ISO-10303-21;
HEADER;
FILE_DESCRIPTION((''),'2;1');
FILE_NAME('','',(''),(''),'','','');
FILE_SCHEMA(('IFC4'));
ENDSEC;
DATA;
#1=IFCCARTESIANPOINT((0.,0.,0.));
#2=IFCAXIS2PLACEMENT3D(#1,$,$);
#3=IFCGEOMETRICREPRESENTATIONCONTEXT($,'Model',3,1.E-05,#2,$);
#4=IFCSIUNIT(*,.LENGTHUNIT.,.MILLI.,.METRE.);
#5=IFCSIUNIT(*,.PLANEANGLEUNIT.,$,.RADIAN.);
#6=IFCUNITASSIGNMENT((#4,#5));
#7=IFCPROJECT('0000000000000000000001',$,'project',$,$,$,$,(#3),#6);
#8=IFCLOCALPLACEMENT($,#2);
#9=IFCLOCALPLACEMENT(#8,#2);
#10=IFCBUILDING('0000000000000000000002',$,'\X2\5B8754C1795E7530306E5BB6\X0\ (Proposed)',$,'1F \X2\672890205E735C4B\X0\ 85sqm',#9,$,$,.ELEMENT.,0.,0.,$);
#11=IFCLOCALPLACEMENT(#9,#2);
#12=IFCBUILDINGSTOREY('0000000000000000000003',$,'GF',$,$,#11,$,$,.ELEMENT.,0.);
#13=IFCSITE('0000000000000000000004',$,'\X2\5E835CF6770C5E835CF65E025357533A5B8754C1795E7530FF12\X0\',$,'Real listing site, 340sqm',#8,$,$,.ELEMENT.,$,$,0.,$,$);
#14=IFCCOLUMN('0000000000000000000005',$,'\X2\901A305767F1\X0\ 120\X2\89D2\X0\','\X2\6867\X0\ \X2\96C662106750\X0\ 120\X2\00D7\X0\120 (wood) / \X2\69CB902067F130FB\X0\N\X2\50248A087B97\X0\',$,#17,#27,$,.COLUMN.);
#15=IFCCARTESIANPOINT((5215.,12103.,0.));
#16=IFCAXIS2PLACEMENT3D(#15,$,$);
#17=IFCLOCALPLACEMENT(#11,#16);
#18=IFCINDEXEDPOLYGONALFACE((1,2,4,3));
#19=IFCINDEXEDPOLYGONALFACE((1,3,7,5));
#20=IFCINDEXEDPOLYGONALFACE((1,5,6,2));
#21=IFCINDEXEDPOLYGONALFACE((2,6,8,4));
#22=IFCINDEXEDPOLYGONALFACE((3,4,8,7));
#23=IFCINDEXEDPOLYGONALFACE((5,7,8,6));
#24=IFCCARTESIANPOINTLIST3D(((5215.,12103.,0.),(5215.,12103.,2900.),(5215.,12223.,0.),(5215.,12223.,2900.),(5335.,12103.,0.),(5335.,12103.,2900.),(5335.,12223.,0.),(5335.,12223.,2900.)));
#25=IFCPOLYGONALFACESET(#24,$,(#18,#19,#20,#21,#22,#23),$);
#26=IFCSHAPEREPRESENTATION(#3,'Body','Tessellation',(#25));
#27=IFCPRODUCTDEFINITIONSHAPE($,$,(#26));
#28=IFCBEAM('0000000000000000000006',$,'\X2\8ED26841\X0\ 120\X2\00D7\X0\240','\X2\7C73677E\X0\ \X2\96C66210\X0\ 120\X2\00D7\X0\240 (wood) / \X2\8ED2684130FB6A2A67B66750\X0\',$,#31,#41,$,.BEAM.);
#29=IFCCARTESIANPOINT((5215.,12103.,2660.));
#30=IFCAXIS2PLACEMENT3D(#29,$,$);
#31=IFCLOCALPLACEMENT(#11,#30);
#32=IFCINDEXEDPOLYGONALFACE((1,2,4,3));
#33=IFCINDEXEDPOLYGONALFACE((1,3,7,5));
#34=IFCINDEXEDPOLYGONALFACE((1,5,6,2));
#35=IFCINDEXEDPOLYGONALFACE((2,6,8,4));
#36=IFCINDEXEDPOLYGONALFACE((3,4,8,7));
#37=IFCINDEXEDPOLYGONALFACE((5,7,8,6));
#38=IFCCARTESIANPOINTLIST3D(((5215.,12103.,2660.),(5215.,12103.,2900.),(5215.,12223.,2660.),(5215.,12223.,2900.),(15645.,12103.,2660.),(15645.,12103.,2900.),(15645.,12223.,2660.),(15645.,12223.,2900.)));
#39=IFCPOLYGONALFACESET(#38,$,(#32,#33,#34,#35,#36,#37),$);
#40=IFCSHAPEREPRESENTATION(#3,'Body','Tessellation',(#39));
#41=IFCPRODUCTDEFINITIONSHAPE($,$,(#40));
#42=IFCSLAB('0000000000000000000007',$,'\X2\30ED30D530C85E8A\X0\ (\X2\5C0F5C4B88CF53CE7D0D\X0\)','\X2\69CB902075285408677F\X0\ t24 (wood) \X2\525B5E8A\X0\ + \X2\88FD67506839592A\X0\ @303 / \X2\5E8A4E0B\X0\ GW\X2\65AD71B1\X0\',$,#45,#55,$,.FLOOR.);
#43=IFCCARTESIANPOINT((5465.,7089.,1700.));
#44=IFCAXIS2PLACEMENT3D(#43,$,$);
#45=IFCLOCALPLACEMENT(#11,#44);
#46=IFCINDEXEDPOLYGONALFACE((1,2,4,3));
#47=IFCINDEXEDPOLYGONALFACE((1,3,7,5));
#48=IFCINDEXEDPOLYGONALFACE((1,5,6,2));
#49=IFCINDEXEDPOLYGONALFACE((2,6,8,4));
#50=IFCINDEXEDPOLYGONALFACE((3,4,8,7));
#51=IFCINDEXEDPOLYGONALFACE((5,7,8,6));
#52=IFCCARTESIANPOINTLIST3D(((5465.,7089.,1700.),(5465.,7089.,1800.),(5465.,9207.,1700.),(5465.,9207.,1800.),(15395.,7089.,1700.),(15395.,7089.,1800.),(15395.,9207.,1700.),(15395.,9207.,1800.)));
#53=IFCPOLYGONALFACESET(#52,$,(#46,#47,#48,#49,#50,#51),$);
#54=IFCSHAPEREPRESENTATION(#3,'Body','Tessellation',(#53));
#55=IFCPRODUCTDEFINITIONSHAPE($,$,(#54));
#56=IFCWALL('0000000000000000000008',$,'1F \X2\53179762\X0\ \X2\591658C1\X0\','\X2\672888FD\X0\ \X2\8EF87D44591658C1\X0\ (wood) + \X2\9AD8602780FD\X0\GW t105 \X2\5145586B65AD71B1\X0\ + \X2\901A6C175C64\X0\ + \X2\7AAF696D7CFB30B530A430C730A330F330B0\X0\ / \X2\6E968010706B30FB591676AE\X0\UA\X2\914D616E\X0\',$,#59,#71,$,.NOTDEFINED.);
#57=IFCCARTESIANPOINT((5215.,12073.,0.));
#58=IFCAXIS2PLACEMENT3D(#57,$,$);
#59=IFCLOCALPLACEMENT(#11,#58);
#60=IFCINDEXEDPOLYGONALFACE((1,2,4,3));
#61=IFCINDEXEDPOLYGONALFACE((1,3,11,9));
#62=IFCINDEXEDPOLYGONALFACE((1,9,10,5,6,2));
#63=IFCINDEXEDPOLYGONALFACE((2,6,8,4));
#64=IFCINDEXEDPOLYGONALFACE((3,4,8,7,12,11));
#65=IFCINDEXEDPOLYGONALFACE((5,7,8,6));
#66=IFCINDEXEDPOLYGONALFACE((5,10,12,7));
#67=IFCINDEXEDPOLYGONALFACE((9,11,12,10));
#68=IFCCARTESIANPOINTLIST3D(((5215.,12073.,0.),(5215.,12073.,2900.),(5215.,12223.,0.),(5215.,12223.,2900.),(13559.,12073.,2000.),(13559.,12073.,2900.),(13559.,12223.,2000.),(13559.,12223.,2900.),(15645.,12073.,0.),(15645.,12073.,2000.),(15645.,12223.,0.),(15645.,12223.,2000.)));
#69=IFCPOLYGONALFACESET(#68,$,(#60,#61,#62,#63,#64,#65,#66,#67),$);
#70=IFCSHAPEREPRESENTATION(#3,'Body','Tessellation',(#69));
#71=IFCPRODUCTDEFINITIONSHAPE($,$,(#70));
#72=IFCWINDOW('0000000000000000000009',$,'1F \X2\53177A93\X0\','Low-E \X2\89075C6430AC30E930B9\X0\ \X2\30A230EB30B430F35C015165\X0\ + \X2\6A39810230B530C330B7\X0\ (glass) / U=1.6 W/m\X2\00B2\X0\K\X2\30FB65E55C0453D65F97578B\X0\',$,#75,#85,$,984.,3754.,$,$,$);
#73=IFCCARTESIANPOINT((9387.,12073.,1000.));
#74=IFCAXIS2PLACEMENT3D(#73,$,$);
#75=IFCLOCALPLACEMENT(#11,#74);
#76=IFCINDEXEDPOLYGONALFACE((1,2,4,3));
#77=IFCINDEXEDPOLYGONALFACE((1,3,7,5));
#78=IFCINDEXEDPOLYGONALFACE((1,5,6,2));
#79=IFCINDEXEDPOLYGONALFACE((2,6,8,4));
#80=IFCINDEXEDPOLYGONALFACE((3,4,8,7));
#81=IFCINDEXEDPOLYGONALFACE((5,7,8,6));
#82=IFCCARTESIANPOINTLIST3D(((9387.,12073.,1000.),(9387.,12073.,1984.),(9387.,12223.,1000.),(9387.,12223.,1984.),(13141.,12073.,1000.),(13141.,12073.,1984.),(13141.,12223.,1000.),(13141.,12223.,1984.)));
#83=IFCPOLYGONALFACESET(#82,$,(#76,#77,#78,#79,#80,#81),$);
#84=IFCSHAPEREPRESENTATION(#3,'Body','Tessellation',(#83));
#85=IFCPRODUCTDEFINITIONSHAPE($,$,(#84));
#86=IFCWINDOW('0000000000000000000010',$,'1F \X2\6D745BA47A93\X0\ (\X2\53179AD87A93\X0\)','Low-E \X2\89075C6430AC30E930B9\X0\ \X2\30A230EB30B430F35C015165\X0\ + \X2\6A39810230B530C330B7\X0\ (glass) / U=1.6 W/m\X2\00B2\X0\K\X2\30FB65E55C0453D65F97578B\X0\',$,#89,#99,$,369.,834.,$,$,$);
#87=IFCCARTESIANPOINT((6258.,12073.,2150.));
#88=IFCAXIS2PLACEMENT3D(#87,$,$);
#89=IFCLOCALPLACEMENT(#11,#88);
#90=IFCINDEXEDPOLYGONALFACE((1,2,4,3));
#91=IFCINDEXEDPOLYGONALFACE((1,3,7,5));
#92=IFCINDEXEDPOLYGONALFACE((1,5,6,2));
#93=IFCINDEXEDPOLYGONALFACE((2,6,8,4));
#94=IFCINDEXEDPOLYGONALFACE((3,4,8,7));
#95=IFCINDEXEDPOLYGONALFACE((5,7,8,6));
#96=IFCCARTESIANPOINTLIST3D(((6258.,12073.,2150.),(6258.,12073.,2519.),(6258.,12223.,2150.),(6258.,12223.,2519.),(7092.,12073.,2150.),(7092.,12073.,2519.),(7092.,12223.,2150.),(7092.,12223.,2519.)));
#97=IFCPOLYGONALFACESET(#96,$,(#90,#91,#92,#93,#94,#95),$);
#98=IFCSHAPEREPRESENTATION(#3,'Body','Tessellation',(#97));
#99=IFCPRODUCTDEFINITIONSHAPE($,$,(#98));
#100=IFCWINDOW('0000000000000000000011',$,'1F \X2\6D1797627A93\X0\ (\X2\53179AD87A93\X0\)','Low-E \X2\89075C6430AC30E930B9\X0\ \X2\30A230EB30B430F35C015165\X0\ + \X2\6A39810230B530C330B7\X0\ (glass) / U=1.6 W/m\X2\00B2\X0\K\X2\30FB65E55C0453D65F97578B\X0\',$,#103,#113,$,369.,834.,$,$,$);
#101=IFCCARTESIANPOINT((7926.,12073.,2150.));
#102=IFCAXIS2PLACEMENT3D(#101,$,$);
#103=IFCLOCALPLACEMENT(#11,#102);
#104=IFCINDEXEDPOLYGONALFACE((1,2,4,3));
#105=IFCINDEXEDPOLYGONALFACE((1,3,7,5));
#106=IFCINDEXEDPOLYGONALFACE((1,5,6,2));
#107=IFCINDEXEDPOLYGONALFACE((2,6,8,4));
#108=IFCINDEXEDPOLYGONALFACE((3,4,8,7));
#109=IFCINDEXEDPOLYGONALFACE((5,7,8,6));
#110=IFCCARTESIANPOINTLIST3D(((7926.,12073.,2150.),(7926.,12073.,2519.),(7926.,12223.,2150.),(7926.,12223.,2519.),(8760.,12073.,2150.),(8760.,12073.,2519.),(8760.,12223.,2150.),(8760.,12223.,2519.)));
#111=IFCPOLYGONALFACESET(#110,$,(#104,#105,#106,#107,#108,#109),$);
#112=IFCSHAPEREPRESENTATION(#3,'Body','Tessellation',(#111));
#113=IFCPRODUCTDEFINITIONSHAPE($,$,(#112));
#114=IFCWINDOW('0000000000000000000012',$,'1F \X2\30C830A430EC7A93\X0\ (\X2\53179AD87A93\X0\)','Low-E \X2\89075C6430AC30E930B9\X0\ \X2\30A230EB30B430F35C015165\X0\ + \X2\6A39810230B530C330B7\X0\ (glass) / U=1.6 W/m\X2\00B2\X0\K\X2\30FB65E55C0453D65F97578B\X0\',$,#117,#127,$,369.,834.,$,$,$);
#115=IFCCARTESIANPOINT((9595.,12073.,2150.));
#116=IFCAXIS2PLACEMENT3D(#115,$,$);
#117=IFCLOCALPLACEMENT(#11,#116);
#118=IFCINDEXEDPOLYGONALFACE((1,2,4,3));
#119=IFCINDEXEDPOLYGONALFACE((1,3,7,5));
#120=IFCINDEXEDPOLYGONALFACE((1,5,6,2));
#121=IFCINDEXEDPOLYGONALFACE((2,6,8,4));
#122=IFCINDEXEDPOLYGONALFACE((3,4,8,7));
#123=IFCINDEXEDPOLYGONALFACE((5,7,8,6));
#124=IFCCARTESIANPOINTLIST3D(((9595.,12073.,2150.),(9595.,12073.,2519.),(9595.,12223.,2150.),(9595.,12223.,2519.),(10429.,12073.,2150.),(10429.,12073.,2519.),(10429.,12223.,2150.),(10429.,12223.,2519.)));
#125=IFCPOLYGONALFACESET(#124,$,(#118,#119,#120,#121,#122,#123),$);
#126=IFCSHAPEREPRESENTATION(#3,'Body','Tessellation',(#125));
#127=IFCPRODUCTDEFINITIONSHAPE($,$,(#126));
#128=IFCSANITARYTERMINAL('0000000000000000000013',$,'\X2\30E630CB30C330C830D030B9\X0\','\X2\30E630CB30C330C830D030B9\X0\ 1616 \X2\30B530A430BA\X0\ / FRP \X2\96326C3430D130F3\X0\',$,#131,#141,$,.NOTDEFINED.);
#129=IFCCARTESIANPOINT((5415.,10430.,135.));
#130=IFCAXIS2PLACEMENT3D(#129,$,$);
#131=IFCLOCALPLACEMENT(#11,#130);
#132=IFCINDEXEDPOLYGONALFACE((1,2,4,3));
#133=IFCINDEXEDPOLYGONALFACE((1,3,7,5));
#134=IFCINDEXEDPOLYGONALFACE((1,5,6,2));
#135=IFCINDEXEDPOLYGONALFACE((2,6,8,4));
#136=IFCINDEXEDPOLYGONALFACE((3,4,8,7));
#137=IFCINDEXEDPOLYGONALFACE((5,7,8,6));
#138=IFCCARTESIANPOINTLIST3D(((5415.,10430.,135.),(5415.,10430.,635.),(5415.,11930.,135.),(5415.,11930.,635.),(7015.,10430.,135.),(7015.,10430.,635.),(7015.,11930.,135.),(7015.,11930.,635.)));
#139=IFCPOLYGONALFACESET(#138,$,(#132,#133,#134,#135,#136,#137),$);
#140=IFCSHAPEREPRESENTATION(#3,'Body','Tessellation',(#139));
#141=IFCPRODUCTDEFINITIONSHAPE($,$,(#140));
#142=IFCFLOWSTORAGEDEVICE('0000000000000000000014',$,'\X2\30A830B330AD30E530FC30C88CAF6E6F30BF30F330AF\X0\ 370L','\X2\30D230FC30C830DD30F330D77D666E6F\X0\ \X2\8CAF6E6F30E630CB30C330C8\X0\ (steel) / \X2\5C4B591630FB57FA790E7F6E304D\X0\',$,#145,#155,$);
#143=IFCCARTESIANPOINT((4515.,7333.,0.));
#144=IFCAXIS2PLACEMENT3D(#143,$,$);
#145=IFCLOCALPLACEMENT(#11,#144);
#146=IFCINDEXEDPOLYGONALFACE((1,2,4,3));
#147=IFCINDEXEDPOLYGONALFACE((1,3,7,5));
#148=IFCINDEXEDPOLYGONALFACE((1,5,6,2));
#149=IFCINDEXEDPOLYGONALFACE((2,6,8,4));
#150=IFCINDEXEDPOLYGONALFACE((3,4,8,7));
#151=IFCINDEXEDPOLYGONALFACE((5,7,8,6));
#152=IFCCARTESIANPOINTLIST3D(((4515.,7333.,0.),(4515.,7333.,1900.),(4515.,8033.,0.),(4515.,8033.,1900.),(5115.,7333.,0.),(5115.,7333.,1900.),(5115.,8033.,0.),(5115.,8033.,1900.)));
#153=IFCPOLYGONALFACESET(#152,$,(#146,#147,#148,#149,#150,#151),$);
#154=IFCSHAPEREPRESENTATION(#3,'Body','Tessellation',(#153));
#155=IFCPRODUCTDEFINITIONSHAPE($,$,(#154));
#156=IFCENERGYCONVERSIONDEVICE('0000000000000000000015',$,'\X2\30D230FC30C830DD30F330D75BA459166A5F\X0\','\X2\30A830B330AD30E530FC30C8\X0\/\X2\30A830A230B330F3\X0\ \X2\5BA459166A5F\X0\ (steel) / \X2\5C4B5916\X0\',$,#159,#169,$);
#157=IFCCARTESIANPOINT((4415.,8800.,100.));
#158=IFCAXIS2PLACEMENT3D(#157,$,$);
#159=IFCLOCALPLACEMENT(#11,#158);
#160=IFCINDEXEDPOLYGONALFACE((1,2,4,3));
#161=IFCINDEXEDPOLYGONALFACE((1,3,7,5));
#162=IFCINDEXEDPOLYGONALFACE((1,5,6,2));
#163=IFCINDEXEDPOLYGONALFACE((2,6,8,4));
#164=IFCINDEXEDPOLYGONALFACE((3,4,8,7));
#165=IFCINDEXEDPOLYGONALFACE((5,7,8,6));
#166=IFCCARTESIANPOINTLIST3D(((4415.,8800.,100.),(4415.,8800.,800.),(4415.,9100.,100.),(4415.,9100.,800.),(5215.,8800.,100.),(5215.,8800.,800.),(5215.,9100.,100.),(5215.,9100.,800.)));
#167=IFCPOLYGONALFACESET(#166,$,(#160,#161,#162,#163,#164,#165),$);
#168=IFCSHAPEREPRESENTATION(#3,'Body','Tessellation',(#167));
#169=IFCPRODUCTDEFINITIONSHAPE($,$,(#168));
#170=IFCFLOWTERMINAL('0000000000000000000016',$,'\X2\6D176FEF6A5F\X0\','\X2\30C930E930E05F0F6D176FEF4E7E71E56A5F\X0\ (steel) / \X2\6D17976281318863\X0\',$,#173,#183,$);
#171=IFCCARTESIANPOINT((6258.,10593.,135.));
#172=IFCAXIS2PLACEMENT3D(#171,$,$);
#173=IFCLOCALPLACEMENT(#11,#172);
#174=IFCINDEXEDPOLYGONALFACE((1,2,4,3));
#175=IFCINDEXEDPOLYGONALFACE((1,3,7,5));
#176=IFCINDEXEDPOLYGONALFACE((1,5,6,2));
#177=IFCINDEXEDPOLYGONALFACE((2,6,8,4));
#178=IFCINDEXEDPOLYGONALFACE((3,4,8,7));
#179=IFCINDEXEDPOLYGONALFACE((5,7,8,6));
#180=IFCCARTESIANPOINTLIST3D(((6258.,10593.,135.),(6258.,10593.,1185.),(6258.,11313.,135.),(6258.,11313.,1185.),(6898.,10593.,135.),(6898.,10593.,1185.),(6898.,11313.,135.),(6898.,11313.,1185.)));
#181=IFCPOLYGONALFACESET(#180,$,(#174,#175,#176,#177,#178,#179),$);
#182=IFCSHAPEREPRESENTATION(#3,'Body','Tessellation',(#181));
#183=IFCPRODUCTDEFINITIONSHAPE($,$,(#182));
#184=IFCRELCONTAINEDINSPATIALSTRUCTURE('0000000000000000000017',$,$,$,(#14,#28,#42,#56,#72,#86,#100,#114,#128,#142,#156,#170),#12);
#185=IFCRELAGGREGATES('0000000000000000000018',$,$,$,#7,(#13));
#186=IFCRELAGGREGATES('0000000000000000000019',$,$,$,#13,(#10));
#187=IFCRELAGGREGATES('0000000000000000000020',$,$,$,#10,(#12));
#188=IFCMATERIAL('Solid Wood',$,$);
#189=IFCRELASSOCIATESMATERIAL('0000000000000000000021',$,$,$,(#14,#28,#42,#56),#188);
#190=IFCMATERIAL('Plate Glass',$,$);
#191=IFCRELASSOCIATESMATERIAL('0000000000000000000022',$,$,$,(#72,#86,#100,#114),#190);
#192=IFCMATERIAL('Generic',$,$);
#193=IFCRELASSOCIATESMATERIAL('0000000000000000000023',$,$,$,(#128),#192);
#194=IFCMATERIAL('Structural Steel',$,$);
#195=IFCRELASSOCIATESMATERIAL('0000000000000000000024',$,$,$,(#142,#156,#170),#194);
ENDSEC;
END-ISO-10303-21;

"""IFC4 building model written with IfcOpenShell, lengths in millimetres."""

from ifc_helpers import new_model, si_unit, frame, frame_2d, origin, place, context, project, spatial, rectangle, extrude, material, element, fill, save


model = new_model("IFC4")

# Units and contexts
model_context = context("Model", 3, precision=1e-05, world=origin())
ifc_project = project(units=[si_unit("LENGTHUNIT", "METRE", prefix="MILLI"), si_unit("PLANEANGLEUNIT", "RADIAN")], contexts=[model_context])

# Site, building, storey
site_placement = place(None, origin())
site = spatial("IfcSite", under=ifc_project, at=site_placement, Name="広島県広島市南区宇品神田２", ObjectType="Real listing site, 340sqm", CompositionType="ELEMENT", RefElevation=0.0)
building_placement = place(site_placement, origin())
building = spatial("IfcBuilding", under=site, at=building_placement, Name="宇品神田の家 (Proposed)", ObjectType="1F 木造平屋 85sqm", CompositionType="ELEMENT", ElevationOfRefHeight=0.0, ElevationOfTerrain=0.0)
storey_placement = place(building_placement, origin())
storey = spatial("IfcBuildingStorey", under=building, at=storey_placement, Name="GF", CompositionType="ELEMENT", Elevation=0.0)

# Column
ifc_material_1 = material(Name="Solid Wood")
column_1_placement = place(storey_placement, frame((5215.0, 12103.0, 0.0)))
element("IfcColumn", 1, at=column_1_placement, inside=storey, material=ifc_material_1, Name="通し柱 120角", Description="桧 集成材 120×120 (wood) / 構造柱・N値計算", PredefinedType="COLUMN", context=model_context, shape_type="SweptSolid", body=[
    extrude(rectangle(XDim=120.0, YDim=120.0, at=frame_2d((60.0, 60.0))), frame((5215.0, 12103.0, 0.0)), (0.0, 0.0, 1.0), 2900.0),
])

# Beam
beam_1_placement = place(storey_placement, frame((5215.0, 12103.0, 2660.0)))
element("IfcBeam", 2, at=beam_1_placement, inside=storey, material=ifc_material_1, Name="軒桁 120×240", Description="米松 集成 120×240 (wood) / 軒桁・横架材", PredefinedType="BEAM", context=model_context, shape_type="SweptSolid", body=[
    extrude(rectangle(XDim=10430.0, YDim=120.0, at=frame_2d((5215.0, 60.0))), frame((5215.0, 12103.0, 2660.0)), (0.0, 0.0, 1.0), 240.0),
])

# Slab
slab_placement = place(storey_placement, frame((5465.0, 7089.0, 1700.0)))
element("IfcSlab", 3, at=slab_placement, inside=storey, material=ifc_material_1, Name="ロフト床 (小屋裏収納)", Description="構造用合板 t24 (wood) 剛床 + 製材根太 @303 / 床下 GW断熱", PredefinedType="FLOOR", context=model_context, shape_type="SweptSolid", body=[
    extrude(rectangle(XDim=9930.0, YDim=2118.0, at=frame_2d((4965.0, 1059.0))), frame((5465.0, 7089.0, 1700.0)), (0.0, 0.0, 1.0), 100.0),
])

# Wall, openings, windows
wall_1_placement = place(storey_placement, frame((5215.0, 12073.0, 0.0)))
wall_1 = element("IfcWall", 4, at=wall_1_placement, inside=storey, material=ifc_material_1, Name="1F 北面 外壁", Description="木製 軸組外壁 (wood) + 高性能GW t105 充填断熱 + 通気層 + 窯業系サイディング / 準耐火・外皮UA配慮", PredefinedType="NOTDEFINED", context=model_context, shape_type="SweptSolid", body=[
    extrude(rectangle(XDim=10430.0, YDim=150.0, at=frame_2d((5215.0, 75.0))), frame((5215.0, 12073.0, 0.0)), (0.0, 0.0, 1.0), 2900.0),
])
opening_1_placement = place(storey_placement, frame((9387.0, 12073.0, 1000.0)))
opening_1 = element("IfcOpeningElement", 5, at=opening_1_placement, cuts=wall_1, PredefinedType="NOTDEFINED", context=model_context, shape_type="SweptSolid", body=[
    extrude(rectangle(XDim=3754.0, YDim=150.0, at=frame_2d((1877.0, 75.0))), frame((9387.0, 12073.0, 1000.0)), (0.0, 0.0, 1.0), 984.0),
])
opening_2_placement = place(storey_placement, frame((6258.0, 12073.0, 2150.0)))
opening_2 = element("IfcOpeningElement", 6, at=opening_2_placement, cuts=wall_1, PredefinedType="NOTDEFINED", context=model_context, shape_type="SweptSolid", body=[
    extrude(rectangle(XDim=834.0, YDim=150.0, at=frame_2d((417.0, 75.0))), frame((6258.0, 12073.0, 2150.0)), (0.0, 0.0, 1.0), 369.0),
])
opening_3_placement = place(storey_placement, frame((7926.0, 12073.0, 2150.0)))
opening_3 = element("IfcOpeningElement", 7, at=opening_3_placement, cuts=wall_1, PredefinedType="NOTDEFINED", context=model_context, shape_type="SweptSolid", body=[
    extrude(rectangle(XDim=834.0, YDim=150.0, at=frame_2d((417.0, 75.0))), frame((7926.0, 12073.0, 2150.0)), (0.0, 0.0, 1.0), 369.0),
])
opening_4_placement = place(storey_placement, frame((9595.0, 12073.0, 2150.0)))
opening_4 = element("IfcOpeningElement", 8, at=opening_4_placement, cuts=wall_1, PredefinedType="NOTDEFINED", context=model_context, shape_type="SweptSolid", body=[
    extrude(rectangle(XDim=834.0, YDim=150.0, at=frame_2d((417.0, 75.0))), frame((9595.0, 12073.0, 2150.0)), (0.0, 0.0, 1.0), 369.0),
])
ifc_material_2 = material(Name="Plate Glass")
window_1_placement = place(storey_placement, frame((9387.0, 12073.0, 1000.0)))
window_1 = element("IfcWindow", 9, at=window_1_placement, inside=storey, material=ifc_material_2, Name="1F 北窓", Description="Low-E 複層ガラス アルゴン封入 + 樹脂サッシ (glass) / U=1.6 W/m²K・日射取得型", OverallHeight=984.0, OverallWidth=3754.0, context=model_context, shape_type="SweptSolid", body=[
    extrude(rectangle(XDim=3754.0, YDim=150.0, at=frame_2d((1877.0, 75.0))), frame((9387.0, 12073.0, 1000.0)), (0.0, 0.0, 1.0), 984.0),
])
fill(opening_1, window_1)
window_2_placement = place(storey_placement, frame((6258.0, 12073.0, 2150.0)))
window_2 = element("IfcWindow", 10, at=window_2_placement, inside=storey, material=ifc_material_2, Name="1F 浴室窓 (北高窓)", Description="Low-E 複層ガラス アルゴン封入 + 樹脂サッシ (glass) / U=1.6 W/m²K・日射取得型", OverallHeight=369.0, OverallWidth=834.0, context=model_context, shape_type="SweptSolid", body=[
    extrude(rectangle(XDim=834.0, YDim=150.0, at=frame_2d((417.0, 75.0))), frame((6258.0, 12073.0, 2150.0)), (0.0, 0.0, 1.0), 369.0),
])
fill(opening_2, window_2)
window_3_placement = place(storey_placement, frame((7926.0, 12073.0, 2150.0)))
window_3 = element("IfcWindow", 11, at=window_3_placement, inside=storey, material=ifc_material_2, Name="1F 洗面窓 (北高窓)", Description="Low-E 複層ガラス アルゴン封入 + 樹脂サッシ (glass) / U=1.6 W/m²K・日射取得型", OverallHeight=369.0, OverallWidth=834.0, context=model_context, shape_type="SweptSolid", body=[
    extrude(rectangle(XDim=834.0, YDim=150.0, at=frame_2d((417.0, 75.0))), frame((7926.0, 12073.0, 2150.0)), (0.0, 0.0, 1.0), 369.0),
])
fill(opening_3, window_3)
window_4_placement = place(storey_placement, frame((9595.0, 12073.0, 2150.0)))
window_4 = element("IfcWindow", 12, at=window_4_placement, inside=storey, material=ifc_material_2, Name="1F トイレ窓 (北高窓)", Description="Low-E 複層ガラス アルゴン封入 + 樹脂サッシ (glass) / U=1.6 W/m²K・日射取得型", OverallHeight=369.0, OverallWidth=834.0, context=model_context, shape_type="SweptSolid", body=[
    extrude(rectangle(XDim=834.0, YDim=150.0, at=frame_2d((417.0, 75.0))), frame((9595.0, 12073.0, 2150.0)), (0.0, 0.0, 1.0), 369.0),
])
fill(opening_4, window_4)

# Sanitary terminal
ifc_material_3 = material(Name="Generic")
sanitary_terminal_placement = place(storey_placement, frame((5415.0, 10430.0, 135.0)))
element("IfcSanitaryTerminal", 13, at=sanitary_terminal_placement, inside=storey, material=ifc_material_3, Name="ユニットバス", Description="ユニットバス 1616 サイズ / FRP 防水パン", PredefinedType="NOTDEFINED", context=model_context, shape_type="SweptSolid", body=[
    extrude(rectangle(XDim=1600.0, YDim=1500.0, at=frame_2d((800.0, 750.0))), frame((5415.0, 10430.0, 135.0)), (0.0, 0.0, 1.0), 500.0),
])

# Flow storage device
ifc_material_4 = material(Name="Structural Steel")
flow_storage_device_placement = place(storey_placement, frame((4515.0, 7333.0, 0.0)))
element("IfcFlowStorageDevice", 14, at=flow_storage_device_placement, inside=storey, material=ifc_material_4, Name="エコキュート貯湯タンク 370L", Description="ヒートポンプ給湯 貯湯ユニット (steel) / 屋外・基礎置き", context=model_context, shape_type="SweptSolid", body=[
    extrude(rectangle(XDim=600.0, YDim=700.0, at=frame_2d((300.0, 350.0))), frame((4515.0, 7333.0, 0.0)), (0.0, 0.0, 1.0), 1900.0),
])

# Energy conversion device
energy_conversion_device_placement = place(storey_placement, frame((4415.0, 8800.0, 100.0)))
element("IfcEnergyConversionDevice", 15, at=energy_conversion_device_placement, inside=storey, material=ifc_material_4, Name="ヒートポンプ室外機", Description="エコキュート/エアコン 室外機 (steel) / 屋外", context=model_context, shape_type="SweptSolid", body=[
    extrude(rectangle(XDim=800.0, YDim=300.0, at=frame_2d((400.0, 150.0))), frame((4415.0, 8800.0, 100.0)), (0.0, 0.0, 1.0), 700.0),
])

# Flow terminal
flow_terminal_placement = place(storey_placement, frame((6258.0, 10593.0, 135.0)))
element("IfcFlowTerminal", 16, at=flow_terminal_placement, inside=storey, material=ifc_material_4, Name="洗濯機", Description="ドラム式洗濯乾燥機 (steel) / 洗面脱衣", context=model_context, shape_type="SweptSolid", body=[
    extrude(rectangle(XDim=640.0, YDim=720.0, at=frame_2d((320.0, 360.0))), frame((6258.0, 10593.0, 135.0)), (0.0, 0.0, 1.0), 1050.0),
])

save(model, "model.ifc")
